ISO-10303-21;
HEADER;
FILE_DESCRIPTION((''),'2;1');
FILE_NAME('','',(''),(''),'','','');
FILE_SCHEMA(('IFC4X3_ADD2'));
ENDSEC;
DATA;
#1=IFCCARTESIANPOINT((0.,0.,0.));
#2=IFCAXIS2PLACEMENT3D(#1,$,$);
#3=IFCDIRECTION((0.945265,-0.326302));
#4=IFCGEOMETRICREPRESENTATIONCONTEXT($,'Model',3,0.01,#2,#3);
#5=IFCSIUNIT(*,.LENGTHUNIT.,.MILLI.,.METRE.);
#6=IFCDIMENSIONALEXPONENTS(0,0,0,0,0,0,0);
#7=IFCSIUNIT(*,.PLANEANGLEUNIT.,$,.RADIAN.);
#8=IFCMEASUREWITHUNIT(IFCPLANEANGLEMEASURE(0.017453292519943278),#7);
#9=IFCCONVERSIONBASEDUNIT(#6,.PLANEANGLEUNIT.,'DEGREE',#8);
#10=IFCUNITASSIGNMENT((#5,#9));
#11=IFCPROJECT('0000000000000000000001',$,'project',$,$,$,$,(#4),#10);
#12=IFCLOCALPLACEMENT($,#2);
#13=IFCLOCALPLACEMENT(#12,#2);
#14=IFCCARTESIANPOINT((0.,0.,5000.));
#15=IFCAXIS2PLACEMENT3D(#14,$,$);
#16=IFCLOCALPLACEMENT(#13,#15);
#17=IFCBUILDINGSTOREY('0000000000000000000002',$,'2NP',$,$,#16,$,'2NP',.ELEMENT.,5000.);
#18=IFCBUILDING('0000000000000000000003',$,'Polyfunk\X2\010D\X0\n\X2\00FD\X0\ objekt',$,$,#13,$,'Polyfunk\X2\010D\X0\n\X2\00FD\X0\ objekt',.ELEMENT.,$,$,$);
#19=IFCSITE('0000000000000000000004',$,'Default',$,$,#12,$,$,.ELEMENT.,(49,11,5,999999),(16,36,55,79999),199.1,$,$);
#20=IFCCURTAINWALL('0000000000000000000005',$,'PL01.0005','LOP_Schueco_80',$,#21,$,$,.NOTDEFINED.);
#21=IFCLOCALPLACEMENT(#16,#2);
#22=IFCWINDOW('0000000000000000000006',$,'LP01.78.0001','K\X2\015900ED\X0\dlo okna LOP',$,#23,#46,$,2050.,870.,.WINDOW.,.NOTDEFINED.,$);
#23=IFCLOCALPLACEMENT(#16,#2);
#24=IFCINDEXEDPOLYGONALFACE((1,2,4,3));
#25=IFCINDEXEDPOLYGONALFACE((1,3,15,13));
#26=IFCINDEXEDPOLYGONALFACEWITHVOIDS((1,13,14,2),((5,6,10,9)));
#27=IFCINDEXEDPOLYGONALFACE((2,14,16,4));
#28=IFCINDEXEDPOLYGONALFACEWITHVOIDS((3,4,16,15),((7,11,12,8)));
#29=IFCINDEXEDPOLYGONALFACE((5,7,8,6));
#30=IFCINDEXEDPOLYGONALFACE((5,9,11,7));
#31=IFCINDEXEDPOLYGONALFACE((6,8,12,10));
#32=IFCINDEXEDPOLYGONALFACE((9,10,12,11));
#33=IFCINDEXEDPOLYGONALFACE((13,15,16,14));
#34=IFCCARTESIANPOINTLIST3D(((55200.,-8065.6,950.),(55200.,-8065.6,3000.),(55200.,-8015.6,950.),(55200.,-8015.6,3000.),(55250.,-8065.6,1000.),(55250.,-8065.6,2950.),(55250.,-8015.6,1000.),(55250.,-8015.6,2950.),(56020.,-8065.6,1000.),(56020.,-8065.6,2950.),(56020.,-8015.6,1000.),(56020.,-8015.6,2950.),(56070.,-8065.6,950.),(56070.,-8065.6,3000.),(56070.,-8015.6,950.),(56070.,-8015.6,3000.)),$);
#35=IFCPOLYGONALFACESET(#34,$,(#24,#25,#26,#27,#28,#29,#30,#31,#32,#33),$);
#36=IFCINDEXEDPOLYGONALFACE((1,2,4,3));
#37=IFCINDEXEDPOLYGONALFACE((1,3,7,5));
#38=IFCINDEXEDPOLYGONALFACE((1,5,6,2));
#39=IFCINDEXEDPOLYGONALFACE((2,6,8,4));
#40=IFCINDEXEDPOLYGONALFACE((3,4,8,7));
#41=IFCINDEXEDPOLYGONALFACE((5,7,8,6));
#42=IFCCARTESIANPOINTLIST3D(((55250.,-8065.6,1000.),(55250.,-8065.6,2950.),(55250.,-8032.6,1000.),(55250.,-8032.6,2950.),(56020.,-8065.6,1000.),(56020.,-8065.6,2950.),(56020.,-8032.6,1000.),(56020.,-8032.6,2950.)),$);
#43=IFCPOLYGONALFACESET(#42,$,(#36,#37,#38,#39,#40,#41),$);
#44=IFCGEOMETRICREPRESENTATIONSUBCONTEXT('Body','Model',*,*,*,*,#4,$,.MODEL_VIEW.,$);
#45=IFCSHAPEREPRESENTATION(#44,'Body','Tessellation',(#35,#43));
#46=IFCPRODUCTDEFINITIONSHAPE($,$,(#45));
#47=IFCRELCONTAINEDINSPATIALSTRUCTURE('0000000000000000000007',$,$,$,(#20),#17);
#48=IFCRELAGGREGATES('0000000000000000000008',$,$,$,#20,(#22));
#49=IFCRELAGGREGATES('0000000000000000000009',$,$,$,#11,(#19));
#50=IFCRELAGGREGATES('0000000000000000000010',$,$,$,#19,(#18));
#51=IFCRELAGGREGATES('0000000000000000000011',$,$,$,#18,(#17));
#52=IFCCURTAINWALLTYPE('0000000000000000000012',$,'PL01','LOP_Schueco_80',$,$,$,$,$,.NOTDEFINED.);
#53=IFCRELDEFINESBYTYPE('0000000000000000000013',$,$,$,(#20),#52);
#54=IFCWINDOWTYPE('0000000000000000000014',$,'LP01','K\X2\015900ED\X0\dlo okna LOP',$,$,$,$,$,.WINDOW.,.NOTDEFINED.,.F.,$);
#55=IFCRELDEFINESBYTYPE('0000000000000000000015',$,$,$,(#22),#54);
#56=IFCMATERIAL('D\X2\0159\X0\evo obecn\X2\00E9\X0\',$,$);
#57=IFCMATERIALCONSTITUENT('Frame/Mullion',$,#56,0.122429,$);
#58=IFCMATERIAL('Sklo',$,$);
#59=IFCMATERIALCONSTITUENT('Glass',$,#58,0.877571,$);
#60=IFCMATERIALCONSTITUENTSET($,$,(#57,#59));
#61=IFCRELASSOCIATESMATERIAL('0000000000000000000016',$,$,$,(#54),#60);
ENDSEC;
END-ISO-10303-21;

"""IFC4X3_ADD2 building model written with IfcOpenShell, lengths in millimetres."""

from ifc_helpers import new_model, entity, si_unit, converted_unit, direction, frame, frame_2d, origin, place, context, subcontext, project, spatial, polyline, rectangle, outline, extrude, source, transform, mapped, material, constituent, constituent_set, type_object, type_shapes, element, aggregate, save


model = new_model("IFC4X3_ADD2")

# Units and contexts
model_context = context("Model", 3, precision=0.01, world=origin(), true_north=direction((0.945265, -0.326302)))
body_context = subcontext(model_context, "Body", "Model", "MODEL_VIEW")
ifc_project = project(units=[si_unit("LENGTHUNIT", "METRE", prefix="MILLI"), converted_unit("PLANEANGLEUNIT", "DEGREE", entity("IfcPlaneAngleMeasure", 0.017453292519943278), si_unit("PLANEANGLEUNIT", "RADIAN"), dimensions=[0, 0, 0, 0, 0, 0, 0])], contexts=[model_context])

# Site, building, storey
site_placement = place(None, origin())
site = spatial("IfcSite", under=ifc_project, at=site_placement, Name="Default", CompositionType="ELEMENT", RefLatitude=(49, 11, 5, 999999), RefLongitude=(16, 36, 55, 79999), RefElevation=199.1)
building_placement = place(site_placement, origin())
building = spatial("IfcBuilding", under=site, at=building_placement, Name="Polyfunkčný objekt", LongName="Polyfunkčný objekt", CompositionType="ELEMENT")
storey_placement = place(building_placement, frame((0.0, 0.0, 5000.0)))
storey = spatial("IfcBuildingStorey", under=building, at=storey_placement, Name="2NP", LongName="2NP", CompositionType="ELEMENT", Elevation=5000.0)

# Curtain wall
curtain_wall_type = type_object("IfcCurtainWallType", Name="PL01", Description="LOP_Schueco_80", PredefinedType="NOTDEFINED")
curtain_wall_placement = place(storey_placement, frame((0.0, 0.0, -5000.0)))
curtain_wall = element("IfcCurtainWall", 1, at=curtain_wall_placement, inside=storey, type_object=curtain_wall_type, Name="PL01.0005", Description="LOP_Schueco_80", PredefinedType="NOTDEFINED")
ifc_material_1 = material(Name="Sklo")

# Window
ifc_material_2 = material(Name="Dřevo obecné")
ifc_constituent_1 = constituent(ifc_material_2, Name="Frame/Mullion", fraction=0.122429)
ifc_constituent_2 = constituent(ifc_material_1, Name="Glass", fraction=0.877571)
ifc_constituent_set = constituent_set(constituents=[ifc_constituent_1, ifc_constituent_2])
window_type = type_object("IfcWindowType", Name="LP01", Description="Křídlo okna LOP", ParameterTakesPrecedence=False, PartitioningType="NOTDEFINED", PredefinedType="WINDOW", material=ifc_constituent_set)
shared_shape_1 = source(origin(), body_context, "Body", "SweptSolid", [
    extrude(outline(polyline([(-1025.0, -435.0), (1025.0, -435.0), (1025.0, 435.0), (-1025.0, 435.0), (-1025.0, -435.0)]), holes=[polyline([(-975.0, -385.0), (-975.0, 385.0), (975.0, 385.0), (975.0, -385.0), (-975.0, -385.0)])]), frame((0.0, 50.0, 1025.0), z_axis=(0.0, -1.0, 0.0), x_axis=(0.0, 0.0, -1.0)), (0.0, 0.0, 1.0), 50.0),
    extrude(rectangle(XDim=770.0, YDim=33.0, at=frame_2d((0.0, 0.0), x_axis=(1.0, 0.0))), frame((0.0, 33.5, 50.0), z_axis=(0.0, 0.0, 1.0), x_axis=(-1.0, 0.0, 0.0)), (0.0, 0.0, 1.0), 1950.0),
])
type_shapes(window_type, [shared_shape_1])
window_placement = place(curtain_wall_placement, frame((55635.0, -8015.6, 5950.0), z_axis=(0.0, 0.0, 1.0), x_axis=(-1.0, 0.0, 0.0)))
window = element("IfcWindow", 2, at=window_placement, type_object=window_type, Name="LP01.78.0001", Description="Křídlo okna LOP", OverallHeight=2050.0, OverallWidth=870.0, PartitioningType="NOTDEFINED", PredefinedType="WINDOW", context=body_context, shape_type="MappedRepresentation", body=[
    mapped(shared_shape_1, transform((0.0, 0.0, 0.0), scale=1.0)),
])
aggregate(curtain_wall, [window])

save(model, "model.ifc")
